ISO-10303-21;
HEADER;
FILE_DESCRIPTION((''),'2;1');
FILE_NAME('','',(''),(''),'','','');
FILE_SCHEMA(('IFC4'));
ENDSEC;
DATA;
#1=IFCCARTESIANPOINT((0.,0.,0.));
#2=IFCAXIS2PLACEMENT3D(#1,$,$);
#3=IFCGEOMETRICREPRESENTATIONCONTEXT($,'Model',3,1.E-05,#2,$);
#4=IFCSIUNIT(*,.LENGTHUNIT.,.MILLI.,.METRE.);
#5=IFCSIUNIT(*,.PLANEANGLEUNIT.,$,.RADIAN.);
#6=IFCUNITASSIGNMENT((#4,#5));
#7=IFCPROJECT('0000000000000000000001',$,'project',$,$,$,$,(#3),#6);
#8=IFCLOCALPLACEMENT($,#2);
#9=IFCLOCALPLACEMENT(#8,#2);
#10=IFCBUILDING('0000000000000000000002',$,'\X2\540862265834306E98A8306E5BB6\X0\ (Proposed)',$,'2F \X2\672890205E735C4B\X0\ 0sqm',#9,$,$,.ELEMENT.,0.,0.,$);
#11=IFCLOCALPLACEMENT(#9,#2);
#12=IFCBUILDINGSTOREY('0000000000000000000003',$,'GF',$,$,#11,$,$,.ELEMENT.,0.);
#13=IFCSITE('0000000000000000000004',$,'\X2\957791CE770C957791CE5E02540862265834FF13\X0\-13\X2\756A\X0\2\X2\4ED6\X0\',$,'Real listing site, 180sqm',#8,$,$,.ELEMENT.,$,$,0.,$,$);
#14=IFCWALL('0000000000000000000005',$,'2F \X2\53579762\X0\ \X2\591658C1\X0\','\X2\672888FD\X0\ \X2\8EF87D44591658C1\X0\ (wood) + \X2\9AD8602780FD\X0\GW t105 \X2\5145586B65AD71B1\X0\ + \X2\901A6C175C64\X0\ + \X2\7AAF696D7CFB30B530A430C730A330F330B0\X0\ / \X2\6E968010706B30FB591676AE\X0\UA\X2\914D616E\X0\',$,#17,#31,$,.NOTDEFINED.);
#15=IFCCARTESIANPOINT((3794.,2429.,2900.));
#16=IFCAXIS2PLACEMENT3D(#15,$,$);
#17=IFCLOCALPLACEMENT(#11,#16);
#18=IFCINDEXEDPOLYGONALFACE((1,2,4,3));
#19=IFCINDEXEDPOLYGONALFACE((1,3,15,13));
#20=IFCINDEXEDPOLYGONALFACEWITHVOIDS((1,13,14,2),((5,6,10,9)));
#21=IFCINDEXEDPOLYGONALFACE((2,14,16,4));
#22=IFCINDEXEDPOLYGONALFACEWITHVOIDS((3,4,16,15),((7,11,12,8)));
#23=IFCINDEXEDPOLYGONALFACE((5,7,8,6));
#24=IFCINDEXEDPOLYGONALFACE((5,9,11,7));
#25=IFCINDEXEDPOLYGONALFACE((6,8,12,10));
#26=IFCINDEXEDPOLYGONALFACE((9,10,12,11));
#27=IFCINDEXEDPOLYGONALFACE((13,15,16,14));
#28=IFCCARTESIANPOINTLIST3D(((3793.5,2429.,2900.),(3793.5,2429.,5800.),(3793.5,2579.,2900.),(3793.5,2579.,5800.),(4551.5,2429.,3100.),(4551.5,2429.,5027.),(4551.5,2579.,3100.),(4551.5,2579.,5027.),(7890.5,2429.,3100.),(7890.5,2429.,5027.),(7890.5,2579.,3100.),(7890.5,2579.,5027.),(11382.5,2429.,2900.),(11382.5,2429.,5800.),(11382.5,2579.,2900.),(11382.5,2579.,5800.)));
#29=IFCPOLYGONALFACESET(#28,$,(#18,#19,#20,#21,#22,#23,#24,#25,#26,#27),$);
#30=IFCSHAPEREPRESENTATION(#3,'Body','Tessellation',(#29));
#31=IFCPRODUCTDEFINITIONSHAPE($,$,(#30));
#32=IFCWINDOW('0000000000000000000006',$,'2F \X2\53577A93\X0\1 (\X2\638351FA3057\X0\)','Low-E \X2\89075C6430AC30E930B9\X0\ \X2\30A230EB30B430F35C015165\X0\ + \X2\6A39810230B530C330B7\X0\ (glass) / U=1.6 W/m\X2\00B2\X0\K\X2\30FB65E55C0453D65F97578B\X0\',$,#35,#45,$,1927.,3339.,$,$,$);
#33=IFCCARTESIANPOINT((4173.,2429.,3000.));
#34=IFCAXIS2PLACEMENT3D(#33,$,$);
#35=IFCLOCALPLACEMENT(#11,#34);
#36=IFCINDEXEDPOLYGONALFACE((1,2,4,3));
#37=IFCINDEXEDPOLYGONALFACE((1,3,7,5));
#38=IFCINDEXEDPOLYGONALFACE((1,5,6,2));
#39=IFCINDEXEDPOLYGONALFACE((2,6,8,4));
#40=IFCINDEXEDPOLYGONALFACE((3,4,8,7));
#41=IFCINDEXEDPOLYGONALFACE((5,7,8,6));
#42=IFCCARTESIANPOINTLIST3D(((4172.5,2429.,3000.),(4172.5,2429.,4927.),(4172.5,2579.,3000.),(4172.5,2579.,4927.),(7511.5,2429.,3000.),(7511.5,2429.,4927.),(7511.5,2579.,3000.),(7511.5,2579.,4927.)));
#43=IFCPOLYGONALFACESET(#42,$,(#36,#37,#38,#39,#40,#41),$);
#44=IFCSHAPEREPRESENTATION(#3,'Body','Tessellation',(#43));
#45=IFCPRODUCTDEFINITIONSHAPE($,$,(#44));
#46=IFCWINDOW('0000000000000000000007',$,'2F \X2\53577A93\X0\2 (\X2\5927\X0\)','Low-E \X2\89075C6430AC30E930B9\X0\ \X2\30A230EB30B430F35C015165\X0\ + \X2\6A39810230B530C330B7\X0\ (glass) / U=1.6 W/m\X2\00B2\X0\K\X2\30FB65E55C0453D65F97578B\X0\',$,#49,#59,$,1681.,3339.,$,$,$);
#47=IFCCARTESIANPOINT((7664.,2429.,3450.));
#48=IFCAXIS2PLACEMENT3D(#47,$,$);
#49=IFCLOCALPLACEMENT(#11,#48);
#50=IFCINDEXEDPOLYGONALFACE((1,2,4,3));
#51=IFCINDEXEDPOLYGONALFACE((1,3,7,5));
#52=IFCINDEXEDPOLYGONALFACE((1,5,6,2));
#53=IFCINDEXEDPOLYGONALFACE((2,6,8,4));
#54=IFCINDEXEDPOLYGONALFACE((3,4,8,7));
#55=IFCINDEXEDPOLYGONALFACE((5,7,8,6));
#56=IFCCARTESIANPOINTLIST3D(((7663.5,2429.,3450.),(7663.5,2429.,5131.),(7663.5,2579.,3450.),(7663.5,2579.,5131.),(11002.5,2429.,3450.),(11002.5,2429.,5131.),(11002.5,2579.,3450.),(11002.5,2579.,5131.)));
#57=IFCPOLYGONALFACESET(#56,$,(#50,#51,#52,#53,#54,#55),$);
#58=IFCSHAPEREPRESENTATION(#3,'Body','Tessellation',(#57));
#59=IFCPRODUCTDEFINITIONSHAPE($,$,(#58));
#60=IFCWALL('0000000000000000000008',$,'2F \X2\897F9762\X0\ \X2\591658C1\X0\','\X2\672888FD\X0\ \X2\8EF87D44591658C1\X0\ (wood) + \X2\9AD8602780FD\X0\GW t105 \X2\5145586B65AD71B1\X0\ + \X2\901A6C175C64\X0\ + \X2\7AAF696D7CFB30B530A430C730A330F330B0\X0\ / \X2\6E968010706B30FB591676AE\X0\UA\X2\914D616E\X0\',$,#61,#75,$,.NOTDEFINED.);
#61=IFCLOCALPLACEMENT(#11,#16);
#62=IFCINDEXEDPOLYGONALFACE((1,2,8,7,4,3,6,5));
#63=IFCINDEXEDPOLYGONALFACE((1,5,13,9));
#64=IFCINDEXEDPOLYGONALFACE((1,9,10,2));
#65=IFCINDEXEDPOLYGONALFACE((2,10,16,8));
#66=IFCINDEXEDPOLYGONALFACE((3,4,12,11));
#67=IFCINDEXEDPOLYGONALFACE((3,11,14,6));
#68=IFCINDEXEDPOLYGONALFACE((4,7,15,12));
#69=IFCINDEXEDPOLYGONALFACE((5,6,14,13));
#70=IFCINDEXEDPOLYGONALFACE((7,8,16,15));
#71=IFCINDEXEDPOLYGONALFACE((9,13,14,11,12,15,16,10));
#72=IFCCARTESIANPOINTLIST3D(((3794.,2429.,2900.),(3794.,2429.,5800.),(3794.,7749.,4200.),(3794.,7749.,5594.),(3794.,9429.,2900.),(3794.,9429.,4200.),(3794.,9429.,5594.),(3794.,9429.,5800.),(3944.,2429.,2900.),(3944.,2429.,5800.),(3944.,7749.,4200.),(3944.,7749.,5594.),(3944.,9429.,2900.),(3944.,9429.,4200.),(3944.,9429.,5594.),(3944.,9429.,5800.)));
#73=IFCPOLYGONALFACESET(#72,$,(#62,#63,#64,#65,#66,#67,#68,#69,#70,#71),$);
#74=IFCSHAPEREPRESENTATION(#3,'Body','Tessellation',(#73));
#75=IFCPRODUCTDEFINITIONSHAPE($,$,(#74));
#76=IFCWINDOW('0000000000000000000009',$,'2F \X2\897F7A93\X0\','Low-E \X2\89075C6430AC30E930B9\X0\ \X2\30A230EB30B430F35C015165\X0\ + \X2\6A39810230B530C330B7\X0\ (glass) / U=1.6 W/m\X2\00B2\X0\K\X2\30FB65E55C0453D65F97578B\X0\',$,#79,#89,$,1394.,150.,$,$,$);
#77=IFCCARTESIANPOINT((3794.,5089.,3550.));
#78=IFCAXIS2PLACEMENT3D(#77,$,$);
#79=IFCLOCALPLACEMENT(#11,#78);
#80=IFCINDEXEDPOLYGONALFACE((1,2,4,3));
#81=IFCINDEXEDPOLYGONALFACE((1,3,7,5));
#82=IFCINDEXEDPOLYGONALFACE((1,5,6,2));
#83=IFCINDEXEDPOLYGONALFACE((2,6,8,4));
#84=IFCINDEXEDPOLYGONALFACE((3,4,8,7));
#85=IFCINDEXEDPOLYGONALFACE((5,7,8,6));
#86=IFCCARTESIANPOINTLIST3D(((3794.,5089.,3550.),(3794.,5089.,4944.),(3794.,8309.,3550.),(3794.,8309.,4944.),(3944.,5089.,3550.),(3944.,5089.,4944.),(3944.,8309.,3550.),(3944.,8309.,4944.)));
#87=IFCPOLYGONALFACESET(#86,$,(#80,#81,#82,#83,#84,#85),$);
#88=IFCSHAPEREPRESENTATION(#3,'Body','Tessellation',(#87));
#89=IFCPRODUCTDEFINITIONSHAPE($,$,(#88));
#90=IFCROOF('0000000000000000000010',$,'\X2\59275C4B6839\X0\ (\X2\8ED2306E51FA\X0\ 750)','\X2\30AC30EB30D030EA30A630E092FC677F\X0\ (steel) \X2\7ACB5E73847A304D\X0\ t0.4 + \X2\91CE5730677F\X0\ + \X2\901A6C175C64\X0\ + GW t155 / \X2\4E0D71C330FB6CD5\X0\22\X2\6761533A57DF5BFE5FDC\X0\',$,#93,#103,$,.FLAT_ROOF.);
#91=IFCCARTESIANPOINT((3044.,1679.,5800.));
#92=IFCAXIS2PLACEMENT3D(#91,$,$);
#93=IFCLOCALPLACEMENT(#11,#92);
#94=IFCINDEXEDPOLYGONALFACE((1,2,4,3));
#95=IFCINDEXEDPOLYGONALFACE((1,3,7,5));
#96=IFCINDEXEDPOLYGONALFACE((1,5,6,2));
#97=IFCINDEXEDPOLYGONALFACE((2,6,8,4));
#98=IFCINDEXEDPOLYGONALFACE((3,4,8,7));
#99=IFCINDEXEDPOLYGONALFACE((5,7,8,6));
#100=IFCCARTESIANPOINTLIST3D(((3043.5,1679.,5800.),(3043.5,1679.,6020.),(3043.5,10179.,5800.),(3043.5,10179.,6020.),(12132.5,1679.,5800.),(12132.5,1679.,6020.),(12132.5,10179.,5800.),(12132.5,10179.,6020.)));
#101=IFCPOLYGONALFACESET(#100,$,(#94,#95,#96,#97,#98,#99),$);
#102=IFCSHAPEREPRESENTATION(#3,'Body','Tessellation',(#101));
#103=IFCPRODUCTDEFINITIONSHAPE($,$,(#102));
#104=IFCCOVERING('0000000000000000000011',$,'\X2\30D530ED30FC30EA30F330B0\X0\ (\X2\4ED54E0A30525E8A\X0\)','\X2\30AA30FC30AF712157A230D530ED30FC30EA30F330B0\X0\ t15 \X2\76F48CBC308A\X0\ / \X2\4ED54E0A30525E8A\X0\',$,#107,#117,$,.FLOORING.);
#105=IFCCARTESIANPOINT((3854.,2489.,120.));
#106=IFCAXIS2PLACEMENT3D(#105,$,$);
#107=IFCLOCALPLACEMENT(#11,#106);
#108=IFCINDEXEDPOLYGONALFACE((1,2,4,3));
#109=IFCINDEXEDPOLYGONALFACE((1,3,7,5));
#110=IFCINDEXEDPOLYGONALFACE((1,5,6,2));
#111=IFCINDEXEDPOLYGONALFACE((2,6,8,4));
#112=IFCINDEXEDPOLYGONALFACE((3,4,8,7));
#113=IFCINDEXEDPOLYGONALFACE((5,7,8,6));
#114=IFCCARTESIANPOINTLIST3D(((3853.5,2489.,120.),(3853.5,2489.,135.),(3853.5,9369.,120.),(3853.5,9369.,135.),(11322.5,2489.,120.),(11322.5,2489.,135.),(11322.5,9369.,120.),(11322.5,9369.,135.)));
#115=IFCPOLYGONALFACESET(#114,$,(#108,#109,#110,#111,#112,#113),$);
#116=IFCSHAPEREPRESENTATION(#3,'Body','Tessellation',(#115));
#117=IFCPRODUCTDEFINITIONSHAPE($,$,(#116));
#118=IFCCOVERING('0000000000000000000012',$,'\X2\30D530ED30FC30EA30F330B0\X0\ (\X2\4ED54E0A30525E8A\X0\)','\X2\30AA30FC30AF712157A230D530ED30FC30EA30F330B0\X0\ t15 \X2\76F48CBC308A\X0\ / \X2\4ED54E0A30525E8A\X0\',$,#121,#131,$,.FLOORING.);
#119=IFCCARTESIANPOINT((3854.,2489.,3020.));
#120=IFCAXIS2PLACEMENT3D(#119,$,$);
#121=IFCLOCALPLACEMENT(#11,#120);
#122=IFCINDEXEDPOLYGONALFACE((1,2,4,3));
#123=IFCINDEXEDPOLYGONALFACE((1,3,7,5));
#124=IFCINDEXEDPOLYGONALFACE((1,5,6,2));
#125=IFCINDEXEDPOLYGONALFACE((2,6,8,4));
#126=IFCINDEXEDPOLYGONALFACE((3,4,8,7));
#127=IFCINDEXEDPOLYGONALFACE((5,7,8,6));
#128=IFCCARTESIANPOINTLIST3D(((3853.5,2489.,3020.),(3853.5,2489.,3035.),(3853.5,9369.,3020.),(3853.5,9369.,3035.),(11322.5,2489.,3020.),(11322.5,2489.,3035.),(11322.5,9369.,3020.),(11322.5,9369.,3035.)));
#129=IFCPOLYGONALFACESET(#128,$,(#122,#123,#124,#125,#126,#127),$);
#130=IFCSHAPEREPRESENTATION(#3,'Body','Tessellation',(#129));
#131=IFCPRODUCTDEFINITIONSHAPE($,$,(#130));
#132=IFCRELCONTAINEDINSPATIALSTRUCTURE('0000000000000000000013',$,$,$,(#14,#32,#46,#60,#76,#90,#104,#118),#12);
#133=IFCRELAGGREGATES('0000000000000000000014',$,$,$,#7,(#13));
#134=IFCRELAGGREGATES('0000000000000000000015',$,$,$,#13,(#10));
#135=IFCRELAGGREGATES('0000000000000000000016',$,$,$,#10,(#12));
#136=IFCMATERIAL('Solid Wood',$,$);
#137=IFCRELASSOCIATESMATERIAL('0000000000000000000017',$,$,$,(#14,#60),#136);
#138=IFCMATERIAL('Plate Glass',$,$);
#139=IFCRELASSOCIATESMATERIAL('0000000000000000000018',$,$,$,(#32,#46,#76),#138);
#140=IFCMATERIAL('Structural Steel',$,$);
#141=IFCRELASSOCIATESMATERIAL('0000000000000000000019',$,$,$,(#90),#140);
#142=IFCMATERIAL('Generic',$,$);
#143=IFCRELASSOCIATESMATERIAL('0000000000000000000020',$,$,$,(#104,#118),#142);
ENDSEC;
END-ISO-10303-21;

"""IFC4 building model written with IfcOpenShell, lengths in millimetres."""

from ifc_helpers import new_model, si_unit, frame, frame_2d, origin, place, context, project, spatial, rectangle, extrude, material, element, fill, save


model = new_model("IFC4")

# Units and contexts
model_context = context("Model", 3, precision=1e-05, world=origin())
ifc_project = project(units=[si_unit("LENGTHUNIT", "METRE", prefix="MILLI"), si_unit("PLANEANGLEUNIT", "RADIAN")], contexts=[model_context])

# Site, building, storey
site_placement = place(None, origin())
site = spatial("IfcSite", under=ifc_project, at=site_placement, Name="長野県長野市合戦場３-13番2他", ObjectType="Real listing site, 180sqm", CompositionType="ELEMENT", RefElevation=0.0)
building_placement = place(site_placement, origin())
building = spatial("IfcBuilding", under=site, at=building_placement, Name="合戦場の風の家 (Proposed)", ObjectType="2F 木造平屋 0sqm", CompositionType="ELEMENT", ElevationOfRefHeight=0.0, ElevationOfTerrain=0.0)
storey_placement = place(building_placement, origin())
storey = spatial("IfcBuildingStorey", under=building, at=storey_placement, Name="GF", CompositionType="ELEMENT", Elevation=0.0)

# Shared definitions
ifc_material_1 = material(Name="Solid Wood")

# Shared definitions
ifc_material_2 = material(Name="Plate Glass")

# Wall, openings, windows
wall_1_placement = place(storey_placement, frame((3794.0, 2429.0, 2900.0)))
wall_1 = element("IfcWall", 1, at=wall_1_placement, inside=storey, material=ifc_material_1, Name="2F 南面 外壁", Description="木製 軸組外壁 (wood) + 高性能GW t105 充填断熱 + 通気層 + 窯業系サイディング / 準耐火・外皮UA配慮", PredefinedType="NOTDEFINED", context=model_context, shape_type="SweptSolid", body=[
    extrude(rectangle(XDim=7589.0, YDim=150.0, at=frame_2d((3794.0, 75.0))), frame((3794.0, 2429.0, 2900.0)), (0.0, 0.0, 1.0), 2900.0),
])
opening_1_placement = place(storey_placement, frame((4173.0, 2429.0, 3000.0)))
opening_1 = element("IfcOpeningElement", 2, at=opening_1_placement, cuts=wall_1, PredefinedType="NOTDEFINED", context=model_context, shape_type="SweptSolid", body=[
    extrude(rectangle(XDim=3339.0, YDim=150.0, at=frame_2d((1669.0, 75.0))), frame((4173.0, 2429.0, 3000.0)), (0.0, 0.0, 1.0), 1927.0),
])
opening_2_placement = place(storey_placement, frame((7664.0, 2429.0, 3450.0)))
opening_2 = element("IfcOpeningElement", 3, at=opening_2_placement, cuts=wall_1, PredefinedType="NOTDEFINED", context=model_context, shape_type="SweptSolid", body=[
    extrude(rectangle(XDim=3339.0, YDim=150.0, at=frame_2d((1669.0, 75.0))), frame((7664.0, 2429.0, 3450.0)), (0.0, 0.0, 1.0), 1681.0),
])
window_1_placement = place(storey_placement, frame((4173.0, 2429.0, 3000.0)))
window_1 = element("IfcWindow", 4, at=window_1_placement, inside=storey, material=ifc_material_2, Name="2F 南窓1 (掃出し)", Description="Low-E 複層ガラス アルゴン封入 + 樹脂サッシ (glass) / U=1.6 W/m²K・日射取得型", OverallHeight=1927.0, OverallWidth=3339.0, context=model_context, shape_type="SweptSolid", body=[
    extrude(rectangle(XDim=3339.0, YDim=150.0, at=frame_2d((1669.0, 75.0))), frame((4173.0, 2429.0, 3000.0)), (0.0, 0.0, 1.0), 1927.0),
])
fill(opening_1, window_1)
window_2_placement = place(storey_placement, frame((7664.0, 2429.0, 3450.0)))
window_2 = element("IfcWindow", 5, at=window_2_placement, inside=storey, material=ifc_material_2, Name="2F 南窓2 (大)", Description="Low-E 複層ガラス アルゴン封入 + 樹脂サッシ (glass) / U=1.6 W/m²K・日射取得型", OverallHeight=1681.0, OverallWidth=3339.0, context=model_context, shape_type="SweptSolid", body=[
    extrude(rectangle(XDim=3339.0, YDim=150.0, at=frame_2d((1669.0, 75.0))), frame((7664.0, 2429.0, 3450.0)), (0.0, 0.0, 1.0), 1681.0),
])
fill(opening_2, window_2)

# Wall, opening, window
wall_2_placement = place(storey_placement, frame((3794.0, 2429.0, 2900.0)))
wall_2 = element("IfcWall", 6, at=wall_2_placement, inside=storey, material=ifc_material_1, Name="2F 西面 外壁", Description="木製 軸組外壁 (wood) + 高性能GW t105 充填断熱 + 通気層 + 窯業系サイディング / 準耐火・外皮UA配慮", PredefinedType="NOTDEFINED", context=model_context, shape_type="SweptSolid", body=[
    extrude(rectangle(XDim=150.0, YDim=7000.0, at=frame_2d((75.0, 3500.0))), frame((3794.0, 2429.0, 2900.0)), (0.0, 0.0, 1.0), 2900.0),
])
opening_3_placement = place(storey_placement, frame((3794.0, 5089.0, 3550.0)))
opening_3 = element("IfcOpeningElement", 7, at=opening_3_placement, cuts=wall_2, PredefinedType="NOTDEFINED", context=model_context, shape_type="SweptSolid", body=[
    extrude(rectangle(XDim=150.0, YDim=3220.0, at=frame_2d((75.0, 1610.0))), frame((3794.0, 5089.0, 3550.0)), (0.0, 0.0, 1.0), 1394.0),
])
window_3_placement = place(storey_placement, frame((3794.0, 5089.0, 3550.0)))
window_3 = element("IfcWindow", 8, at=window_3_placement, inside=storey, material=ifc_material_2, Name="2F 西窓", Description="Low-E 複層ガラス アルゴン封入 + 樹脂サッシ (glass) / U=1.6 W/m²K・日射取得型", OverallHeight=1394.0, OverallWidth=150.0, context=model_context, shape_type="SweptSolid", body=[
    extrude(rectangle(XDim=150.0, YDim=3220.0, at=frame_2d((75.0, 1610.0))), frame((3794.0, 5089.0, 3550.0)), (0.0, 0.0, 1.0), 1394.0),
])
fill(opening_3, window_3)

# Roof
ifc_material_3 = material(Name="Structural Steel")
roof_placement = place(storey_placement, frame((3044.0, 1679.0, 5800.0)))
element("IfcRoof", 9, at=roof_placement, inside=storey, material=ifc_material_3, Name="大屋根 (軒の出 750)", Description="ガルバリウム鋼板 (steel) 立平葺き t0.4 + 野地板 + 通気層 + GW t155 / 不燃・法22条区域対応", PredefinedType="FLAT_ROOF", context=model_context, shape_type="SweptSolid", body=[
    extrude(rectangle(XDim=9089.0, YDim=8500.0, at=frame_2d((4544.0, 4250.0))), frame((3044.0, 1679.0, 5800.0)), (0.0, 0.0, 1.0), 220.0),
])

# Coverings
ifc_material_4 = material(Name="Generic")
covering_1_placement = place(storey_placement, frame((3854.0, 2489.0, 120.0)))
element("IfcCovering", 10, at=covering_1_placement, inside=storey, material=ifc_material_4, Name="フローリング (仕上げ床)", Description="オーク無垢フローリング t15 直貼り / 仕上げ床", PredefinedType="FLOORING", context=model_context, shape_type="SweptSolid", body=[
    extrude(rectangle(XDim=7469.0, YDim=6880.0, at=frame_2d((3734.0, 3440.0))), frame((3854.0, 2489.0, 120.0)), (0.0, 0.0, 1.0), 15.0),
])
covering_2_placement = place(storey_placement, frame((3854.0, 2489.0, 3020.0)))
element("IfcCovering", 11, at=covering_2_placement, inside=storey, material=ifc_material_4, Name="フローリング (仕上げ床)", Description="オーク無垢フローリング t15 直貼り / 仕上げ床", PredefinedType="FLOORING", context=model_context, shape_type="SweptSolid", body=[
    extrude(rectangle(XDim=7469.0, YDim=6880.0, at=frame_2d((3734.0, 3440.0))), frame((3854.0, 2489.0, 3020.0)), (0.0, 0.0, 1.0), 15.0),
])

save(model, "model.ifc")
